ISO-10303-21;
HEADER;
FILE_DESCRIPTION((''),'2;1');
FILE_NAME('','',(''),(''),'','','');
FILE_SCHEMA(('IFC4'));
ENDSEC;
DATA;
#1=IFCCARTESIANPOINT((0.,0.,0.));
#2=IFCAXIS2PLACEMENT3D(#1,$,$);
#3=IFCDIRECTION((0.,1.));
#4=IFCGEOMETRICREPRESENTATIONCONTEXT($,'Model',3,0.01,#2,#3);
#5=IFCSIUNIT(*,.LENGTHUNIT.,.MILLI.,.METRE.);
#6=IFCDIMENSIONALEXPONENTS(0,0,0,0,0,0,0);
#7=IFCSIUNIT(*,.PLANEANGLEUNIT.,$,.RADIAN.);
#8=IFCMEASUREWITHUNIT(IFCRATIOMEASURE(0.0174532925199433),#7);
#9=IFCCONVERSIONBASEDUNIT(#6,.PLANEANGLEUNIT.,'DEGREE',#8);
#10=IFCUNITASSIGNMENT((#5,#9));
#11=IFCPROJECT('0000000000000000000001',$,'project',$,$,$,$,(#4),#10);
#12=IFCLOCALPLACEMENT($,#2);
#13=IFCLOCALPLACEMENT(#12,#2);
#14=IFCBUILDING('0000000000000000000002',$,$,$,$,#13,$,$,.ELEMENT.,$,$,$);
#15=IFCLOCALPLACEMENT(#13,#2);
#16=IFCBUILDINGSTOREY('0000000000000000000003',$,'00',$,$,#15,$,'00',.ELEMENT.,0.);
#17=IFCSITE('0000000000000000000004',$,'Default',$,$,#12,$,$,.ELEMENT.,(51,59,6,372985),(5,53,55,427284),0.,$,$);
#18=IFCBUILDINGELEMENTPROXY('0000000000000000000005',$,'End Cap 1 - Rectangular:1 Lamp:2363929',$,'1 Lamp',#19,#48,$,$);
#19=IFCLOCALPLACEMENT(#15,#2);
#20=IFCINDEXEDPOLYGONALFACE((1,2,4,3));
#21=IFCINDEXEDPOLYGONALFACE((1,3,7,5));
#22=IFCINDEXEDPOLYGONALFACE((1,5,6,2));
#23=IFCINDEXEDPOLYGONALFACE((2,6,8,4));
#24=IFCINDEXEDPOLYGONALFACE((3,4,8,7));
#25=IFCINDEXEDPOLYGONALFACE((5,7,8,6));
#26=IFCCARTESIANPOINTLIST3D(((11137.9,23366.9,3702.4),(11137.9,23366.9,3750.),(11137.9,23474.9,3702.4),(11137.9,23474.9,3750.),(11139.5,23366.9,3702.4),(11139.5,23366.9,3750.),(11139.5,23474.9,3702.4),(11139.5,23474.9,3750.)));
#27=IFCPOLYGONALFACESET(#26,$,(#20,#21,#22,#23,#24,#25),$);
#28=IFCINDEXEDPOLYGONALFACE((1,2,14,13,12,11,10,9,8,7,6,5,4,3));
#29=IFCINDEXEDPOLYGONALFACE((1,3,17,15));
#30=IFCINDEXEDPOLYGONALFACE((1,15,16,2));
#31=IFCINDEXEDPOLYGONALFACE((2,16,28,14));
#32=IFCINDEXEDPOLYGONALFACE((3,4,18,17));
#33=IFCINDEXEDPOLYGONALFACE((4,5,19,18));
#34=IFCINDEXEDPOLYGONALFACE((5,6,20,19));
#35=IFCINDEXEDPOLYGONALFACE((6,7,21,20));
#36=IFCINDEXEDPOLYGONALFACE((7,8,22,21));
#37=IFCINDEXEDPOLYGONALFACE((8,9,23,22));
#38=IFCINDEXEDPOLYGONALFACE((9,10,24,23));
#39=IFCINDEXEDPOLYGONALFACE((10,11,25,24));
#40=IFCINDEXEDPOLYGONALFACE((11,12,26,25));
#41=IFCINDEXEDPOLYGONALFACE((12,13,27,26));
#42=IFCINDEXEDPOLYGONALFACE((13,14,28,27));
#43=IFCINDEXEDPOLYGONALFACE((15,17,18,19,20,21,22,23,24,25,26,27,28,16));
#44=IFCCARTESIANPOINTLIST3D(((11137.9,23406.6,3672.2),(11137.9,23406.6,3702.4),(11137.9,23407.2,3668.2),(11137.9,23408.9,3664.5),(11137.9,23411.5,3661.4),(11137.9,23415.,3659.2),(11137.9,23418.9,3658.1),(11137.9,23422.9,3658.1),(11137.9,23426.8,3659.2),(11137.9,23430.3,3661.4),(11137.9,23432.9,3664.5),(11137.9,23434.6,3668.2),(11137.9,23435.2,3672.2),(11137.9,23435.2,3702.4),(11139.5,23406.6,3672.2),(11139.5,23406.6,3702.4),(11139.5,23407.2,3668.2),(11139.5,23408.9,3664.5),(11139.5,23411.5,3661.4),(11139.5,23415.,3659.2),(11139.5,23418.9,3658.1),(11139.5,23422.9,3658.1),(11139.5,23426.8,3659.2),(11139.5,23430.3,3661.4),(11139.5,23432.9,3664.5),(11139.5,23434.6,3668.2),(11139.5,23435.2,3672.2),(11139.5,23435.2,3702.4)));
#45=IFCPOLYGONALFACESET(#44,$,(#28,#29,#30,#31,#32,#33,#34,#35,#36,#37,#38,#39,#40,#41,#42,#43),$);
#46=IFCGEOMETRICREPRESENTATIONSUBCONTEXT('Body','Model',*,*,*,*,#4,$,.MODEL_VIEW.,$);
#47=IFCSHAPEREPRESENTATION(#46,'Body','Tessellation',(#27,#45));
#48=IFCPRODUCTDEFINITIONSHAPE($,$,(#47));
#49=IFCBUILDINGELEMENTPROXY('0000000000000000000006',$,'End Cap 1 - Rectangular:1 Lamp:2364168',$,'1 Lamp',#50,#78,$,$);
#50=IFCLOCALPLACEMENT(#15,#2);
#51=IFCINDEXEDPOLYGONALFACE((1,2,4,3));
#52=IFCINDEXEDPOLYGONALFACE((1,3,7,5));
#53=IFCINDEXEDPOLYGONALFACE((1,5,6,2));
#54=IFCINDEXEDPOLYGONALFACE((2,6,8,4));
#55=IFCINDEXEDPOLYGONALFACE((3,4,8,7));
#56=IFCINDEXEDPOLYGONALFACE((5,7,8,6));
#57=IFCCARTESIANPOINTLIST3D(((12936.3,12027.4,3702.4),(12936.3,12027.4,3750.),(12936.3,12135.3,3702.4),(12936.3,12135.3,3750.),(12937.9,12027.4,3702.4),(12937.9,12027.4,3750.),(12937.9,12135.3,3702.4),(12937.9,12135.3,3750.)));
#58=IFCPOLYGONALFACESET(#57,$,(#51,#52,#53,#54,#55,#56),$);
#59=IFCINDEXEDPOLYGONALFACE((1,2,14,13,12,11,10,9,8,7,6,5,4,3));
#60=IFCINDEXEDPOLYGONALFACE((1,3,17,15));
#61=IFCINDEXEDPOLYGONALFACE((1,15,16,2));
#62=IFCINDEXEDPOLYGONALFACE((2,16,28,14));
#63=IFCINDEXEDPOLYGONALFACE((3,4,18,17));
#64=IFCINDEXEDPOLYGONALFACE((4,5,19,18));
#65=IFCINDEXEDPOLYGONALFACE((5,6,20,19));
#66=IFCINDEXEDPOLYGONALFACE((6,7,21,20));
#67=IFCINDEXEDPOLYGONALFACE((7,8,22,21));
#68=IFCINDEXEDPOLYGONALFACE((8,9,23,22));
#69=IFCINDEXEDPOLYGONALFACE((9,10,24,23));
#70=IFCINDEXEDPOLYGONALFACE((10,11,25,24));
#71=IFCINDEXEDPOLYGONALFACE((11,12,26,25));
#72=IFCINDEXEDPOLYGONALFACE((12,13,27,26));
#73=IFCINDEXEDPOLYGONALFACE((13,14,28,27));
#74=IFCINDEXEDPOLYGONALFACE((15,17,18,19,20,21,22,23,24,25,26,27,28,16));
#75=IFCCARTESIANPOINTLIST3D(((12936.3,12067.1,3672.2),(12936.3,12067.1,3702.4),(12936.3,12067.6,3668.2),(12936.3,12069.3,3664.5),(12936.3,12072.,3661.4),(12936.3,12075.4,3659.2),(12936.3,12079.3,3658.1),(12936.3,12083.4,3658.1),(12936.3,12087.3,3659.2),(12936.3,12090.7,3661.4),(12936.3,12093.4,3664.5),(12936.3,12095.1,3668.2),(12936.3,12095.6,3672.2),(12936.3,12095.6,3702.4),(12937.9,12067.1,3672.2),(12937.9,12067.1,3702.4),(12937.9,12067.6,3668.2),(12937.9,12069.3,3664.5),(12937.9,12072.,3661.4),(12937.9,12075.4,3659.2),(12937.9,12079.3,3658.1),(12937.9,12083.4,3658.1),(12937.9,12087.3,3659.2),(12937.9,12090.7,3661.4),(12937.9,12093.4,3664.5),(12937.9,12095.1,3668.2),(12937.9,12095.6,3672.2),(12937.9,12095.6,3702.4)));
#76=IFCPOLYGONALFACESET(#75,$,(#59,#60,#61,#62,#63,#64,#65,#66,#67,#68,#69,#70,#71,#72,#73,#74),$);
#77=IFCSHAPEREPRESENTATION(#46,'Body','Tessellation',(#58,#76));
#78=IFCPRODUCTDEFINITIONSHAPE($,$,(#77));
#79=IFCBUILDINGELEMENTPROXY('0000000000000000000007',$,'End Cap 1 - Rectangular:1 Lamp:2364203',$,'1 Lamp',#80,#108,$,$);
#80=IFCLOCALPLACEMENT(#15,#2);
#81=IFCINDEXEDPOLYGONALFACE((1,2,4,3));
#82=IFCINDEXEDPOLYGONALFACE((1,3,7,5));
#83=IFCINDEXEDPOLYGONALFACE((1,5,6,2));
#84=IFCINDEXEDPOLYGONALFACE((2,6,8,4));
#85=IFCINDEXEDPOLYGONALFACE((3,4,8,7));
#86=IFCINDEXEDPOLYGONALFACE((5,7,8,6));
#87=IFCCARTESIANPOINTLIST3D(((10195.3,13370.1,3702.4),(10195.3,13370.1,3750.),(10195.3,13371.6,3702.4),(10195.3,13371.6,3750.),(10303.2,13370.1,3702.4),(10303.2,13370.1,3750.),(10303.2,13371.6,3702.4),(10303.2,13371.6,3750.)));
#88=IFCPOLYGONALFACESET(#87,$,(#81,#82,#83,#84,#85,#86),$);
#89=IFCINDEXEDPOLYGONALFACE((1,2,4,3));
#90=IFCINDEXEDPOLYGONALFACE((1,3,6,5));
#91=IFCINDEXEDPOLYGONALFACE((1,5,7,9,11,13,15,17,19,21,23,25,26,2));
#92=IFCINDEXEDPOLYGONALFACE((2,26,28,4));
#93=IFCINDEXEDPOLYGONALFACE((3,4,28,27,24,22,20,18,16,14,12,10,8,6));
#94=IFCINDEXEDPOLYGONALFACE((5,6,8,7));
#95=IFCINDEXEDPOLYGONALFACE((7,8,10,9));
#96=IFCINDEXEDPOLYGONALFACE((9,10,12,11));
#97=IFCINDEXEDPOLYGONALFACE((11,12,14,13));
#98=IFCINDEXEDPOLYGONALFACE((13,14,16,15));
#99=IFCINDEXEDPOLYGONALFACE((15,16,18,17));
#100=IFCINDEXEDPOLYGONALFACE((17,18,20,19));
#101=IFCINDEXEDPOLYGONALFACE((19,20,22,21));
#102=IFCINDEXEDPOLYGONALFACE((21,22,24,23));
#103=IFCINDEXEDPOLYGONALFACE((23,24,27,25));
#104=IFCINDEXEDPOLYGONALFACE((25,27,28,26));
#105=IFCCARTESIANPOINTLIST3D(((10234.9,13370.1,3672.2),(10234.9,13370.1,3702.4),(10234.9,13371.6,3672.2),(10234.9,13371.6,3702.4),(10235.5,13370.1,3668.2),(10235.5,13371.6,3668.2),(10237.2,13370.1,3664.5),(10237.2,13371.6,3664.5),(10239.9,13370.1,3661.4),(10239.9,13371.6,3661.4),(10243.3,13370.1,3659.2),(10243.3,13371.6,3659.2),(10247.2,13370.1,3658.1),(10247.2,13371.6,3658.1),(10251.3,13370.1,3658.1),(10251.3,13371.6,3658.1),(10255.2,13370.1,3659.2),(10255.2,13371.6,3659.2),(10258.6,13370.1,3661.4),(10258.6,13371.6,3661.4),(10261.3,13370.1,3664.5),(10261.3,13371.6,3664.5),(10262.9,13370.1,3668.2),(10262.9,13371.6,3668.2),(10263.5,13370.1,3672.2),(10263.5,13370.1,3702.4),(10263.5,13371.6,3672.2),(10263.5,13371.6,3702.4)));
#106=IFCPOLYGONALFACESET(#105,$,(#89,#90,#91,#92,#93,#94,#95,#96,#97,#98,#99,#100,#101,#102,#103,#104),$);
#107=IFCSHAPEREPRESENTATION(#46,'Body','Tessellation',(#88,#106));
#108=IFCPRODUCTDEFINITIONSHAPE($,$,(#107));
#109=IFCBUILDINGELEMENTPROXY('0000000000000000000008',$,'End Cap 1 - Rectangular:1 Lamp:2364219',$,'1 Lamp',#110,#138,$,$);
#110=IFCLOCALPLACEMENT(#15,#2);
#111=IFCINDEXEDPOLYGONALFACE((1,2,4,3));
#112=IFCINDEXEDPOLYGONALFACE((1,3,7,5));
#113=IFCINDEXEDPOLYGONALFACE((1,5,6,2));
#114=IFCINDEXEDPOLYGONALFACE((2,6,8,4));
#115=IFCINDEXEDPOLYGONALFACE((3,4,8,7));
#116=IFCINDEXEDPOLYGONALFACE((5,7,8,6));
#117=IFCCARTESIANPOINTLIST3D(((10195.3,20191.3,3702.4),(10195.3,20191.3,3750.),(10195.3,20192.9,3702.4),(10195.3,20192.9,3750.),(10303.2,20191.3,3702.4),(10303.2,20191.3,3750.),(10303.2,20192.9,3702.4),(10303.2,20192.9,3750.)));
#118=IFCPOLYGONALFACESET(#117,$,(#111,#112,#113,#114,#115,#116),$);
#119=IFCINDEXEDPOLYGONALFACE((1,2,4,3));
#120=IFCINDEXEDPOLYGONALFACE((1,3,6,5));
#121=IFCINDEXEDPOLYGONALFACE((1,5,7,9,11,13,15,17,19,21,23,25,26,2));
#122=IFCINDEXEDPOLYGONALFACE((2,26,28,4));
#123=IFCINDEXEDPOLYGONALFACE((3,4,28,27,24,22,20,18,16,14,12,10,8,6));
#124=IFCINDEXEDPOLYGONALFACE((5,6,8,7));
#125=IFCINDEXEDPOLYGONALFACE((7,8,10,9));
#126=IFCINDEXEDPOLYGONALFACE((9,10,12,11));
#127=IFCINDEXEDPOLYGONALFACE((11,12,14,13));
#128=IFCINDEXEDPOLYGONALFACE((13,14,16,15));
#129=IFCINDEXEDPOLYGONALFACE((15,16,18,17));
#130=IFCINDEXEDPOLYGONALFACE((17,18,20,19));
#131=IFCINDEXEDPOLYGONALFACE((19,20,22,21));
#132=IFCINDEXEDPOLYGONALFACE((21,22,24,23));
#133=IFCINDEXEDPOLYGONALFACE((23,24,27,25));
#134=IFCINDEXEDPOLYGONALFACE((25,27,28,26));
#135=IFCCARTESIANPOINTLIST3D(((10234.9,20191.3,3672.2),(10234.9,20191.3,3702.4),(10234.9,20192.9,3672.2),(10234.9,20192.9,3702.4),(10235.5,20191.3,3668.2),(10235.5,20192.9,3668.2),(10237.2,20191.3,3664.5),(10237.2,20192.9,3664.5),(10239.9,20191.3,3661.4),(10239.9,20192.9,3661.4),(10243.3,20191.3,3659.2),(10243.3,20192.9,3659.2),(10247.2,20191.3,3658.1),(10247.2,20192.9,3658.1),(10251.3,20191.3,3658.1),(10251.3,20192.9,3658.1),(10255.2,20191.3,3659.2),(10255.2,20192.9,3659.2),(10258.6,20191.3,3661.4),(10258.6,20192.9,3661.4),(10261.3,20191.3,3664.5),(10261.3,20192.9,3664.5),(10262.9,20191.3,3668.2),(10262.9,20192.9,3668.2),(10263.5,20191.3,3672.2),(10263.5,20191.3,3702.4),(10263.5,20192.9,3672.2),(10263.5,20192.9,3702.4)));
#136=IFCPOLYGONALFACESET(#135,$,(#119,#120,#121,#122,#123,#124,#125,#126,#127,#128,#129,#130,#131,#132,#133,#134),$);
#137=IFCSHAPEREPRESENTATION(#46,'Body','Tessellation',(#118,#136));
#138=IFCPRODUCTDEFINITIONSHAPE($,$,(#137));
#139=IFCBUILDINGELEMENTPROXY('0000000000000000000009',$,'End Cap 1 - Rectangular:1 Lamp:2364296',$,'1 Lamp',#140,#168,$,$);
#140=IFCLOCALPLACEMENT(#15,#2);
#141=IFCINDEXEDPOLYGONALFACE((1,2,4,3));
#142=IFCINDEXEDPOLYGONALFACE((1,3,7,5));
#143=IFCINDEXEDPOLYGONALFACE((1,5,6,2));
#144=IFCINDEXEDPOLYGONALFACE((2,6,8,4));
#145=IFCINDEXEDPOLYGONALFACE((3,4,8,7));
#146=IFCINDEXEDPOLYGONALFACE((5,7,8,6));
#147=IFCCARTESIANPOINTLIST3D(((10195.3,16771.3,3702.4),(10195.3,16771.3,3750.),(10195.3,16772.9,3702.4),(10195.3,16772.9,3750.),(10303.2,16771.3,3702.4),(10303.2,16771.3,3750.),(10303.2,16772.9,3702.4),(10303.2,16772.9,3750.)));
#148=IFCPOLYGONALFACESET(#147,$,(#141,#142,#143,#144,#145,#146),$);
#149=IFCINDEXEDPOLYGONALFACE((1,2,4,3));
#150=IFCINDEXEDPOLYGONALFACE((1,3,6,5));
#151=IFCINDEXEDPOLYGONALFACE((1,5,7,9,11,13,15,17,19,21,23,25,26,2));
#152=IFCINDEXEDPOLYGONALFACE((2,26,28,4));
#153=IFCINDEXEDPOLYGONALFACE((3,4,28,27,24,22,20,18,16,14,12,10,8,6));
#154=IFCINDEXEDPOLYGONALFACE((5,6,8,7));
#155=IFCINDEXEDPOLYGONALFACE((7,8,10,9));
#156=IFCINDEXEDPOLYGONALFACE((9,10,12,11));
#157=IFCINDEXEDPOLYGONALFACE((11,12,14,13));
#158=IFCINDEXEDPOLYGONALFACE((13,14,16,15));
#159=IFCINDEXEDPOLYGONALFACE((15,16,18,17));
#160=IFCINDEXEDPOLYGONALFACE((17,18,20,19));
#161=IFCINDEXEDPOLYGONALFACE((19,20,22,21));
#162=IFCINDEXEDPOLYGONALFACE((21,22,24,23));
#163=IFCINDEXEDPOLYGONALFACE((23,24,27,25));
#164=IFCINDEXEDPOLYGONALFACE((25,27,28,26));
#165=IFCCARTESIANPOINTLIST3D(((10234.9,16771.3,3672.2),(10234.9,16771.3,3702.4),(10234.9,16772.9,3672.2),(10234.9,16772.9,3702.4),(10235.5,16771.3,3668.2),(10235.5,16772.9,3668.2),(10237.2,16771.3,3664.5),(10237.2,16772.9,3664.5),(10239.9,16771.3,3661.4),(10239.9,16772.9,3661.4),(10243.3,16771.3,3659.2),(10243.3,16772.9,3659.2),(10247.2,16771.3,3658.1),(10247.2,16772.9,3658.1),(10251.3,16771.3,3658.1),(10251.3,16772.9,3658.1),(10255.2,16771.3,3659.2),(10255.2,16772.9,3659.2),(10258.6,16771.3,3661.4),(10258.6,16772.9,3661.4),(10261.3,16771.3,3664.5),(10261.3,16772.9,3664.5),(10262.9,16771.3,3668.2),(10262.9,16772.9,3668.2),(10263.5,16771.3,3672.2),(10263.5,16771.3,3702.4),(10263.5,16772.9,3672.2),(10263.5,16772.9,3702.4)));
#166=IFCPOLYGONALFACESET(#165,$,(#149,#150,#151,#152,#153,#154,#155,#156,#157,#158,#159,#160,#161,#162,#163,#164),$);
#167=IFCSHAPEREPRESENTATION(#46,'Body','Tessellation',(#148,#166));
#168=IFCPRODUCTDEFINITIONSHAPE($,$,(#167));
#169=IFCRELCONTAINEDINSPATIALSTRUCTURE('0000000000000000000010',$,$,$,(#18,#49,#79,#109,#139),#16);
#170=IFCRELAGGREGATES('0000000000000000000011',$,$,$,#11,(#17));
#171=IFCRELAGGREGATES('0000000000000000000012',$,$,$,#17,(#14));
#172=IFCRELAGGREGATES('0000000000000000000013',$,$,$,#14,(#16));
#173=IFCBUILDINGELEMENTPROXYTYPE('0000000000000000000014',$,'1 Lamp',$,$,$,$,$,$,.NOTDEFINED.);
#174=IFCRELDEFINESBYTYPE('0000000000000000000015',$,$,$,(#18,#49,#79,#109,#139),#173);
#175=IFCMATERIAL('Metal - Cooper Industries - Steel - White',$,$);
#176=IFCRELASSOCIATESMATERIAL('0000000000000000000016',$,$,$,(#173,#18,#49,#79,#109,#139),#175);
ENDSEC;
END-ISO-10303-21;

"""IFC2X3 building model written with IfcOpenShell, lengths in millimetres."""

from ifc_helpers import new_model, entity, si_unit, converted_unit, direction, frame, frame_2d, origin, origin_2d_with_axis, place, context, subcontext, project, spatial, polyline, circle_curve, parameter, trimmed, segment, composite_curve, rectangle, outline, extrude, source, transform, mapped, material, type_object, type_shapes, element, save


model = new_model("IFC2X3")

# Units and contexts
model_context = context("Model", 3, precision=0.01, world=origin(), true_north=direction((0.0, 1.0)))
body_context = subcontext(model_context, "Body", "Model", "MODEL_VIEW")
ifc_project = project(units=[si_unit("LENGTHUNIT", "METRE", prefix="MILLI"), converted_unit("PLANEANGLEUNIT", "DEGREE", entity("IfcRatioMeasure", 0.0174532925199433), si_unit("PLANEANGLEUNIT", "RADIAN"), dimensions=[0, 0, 0, 0, 0, 0, 0])], contexts=[model_context])

# Site, building, storey
site_placement = place(None, origin())
site = spatial("IfcSite", under=ifc_project, at=site_placement, Name="Default", CompositionType="ELEMENT", RefLatitude=(51, 59, 6, 372985), RefLongitude=(5, 53, 55, 427284), RefElevation=0.0)
building_placement = place(site_placement, origin())
building = spatial("IfcBuilding", under=site, at=building_placement, CompositionType="ELEMENT")
storey_placement = place(building_placement, origin())
storey = spatial("IfcBuildingStorey", under=building, at=storey_placement, Name="00", LongName="00", CompositionType="ELEMENT", Elevation=0.0)

# Building element proxies
ifc_material_1 = material(Name="Metal - Cooper Industries - Steel - White")
building_element_proxy_type_1 = type_object("IfcBuildingElementProxyType", Name="1 Lamp", PredefinedType="NOTDEFINED", material=ifc_material_1)
shared_shape_1 = source(origin(), body_context, "Body", "SweptSolid", [
    extrude(rectangle(XDim=108.0, YDim=1.6, at=origin_2d_with_axis()), frame((0.0, 0.0, 0.0), z_axis=(0.0, 0.0, 1.0), x_axis=(-1.0, 0.0, 0.0)), (0.0, 0.0, 1.0), 47.6),
    extrude(outline(composite_curve([segment(polyline([(-15.1, -14.3), (15.1, -14.3)]), True, "CONTINUOUS"), segment(polyline([(15.1, -14.3), (15.1, 14.3)]), True, "CONTINUOUS"), segment(polyline([(15.1, 14.3), (-15.1, 14.3)]), True, "CONTINUOUS"), segment(trimmed(circle_curve(frame_2d((-15.1, 0.0), x_axis=(0.0, -1.0)), 14.3), [parameter(180.0)], [parameter(0.0)], True, "PARAMETER"), True, "CONTINUOUS")], self_intersect=False)), frame((0.0, -0.8, 62.7), z_axis=(0.0, 1.0, 0.0), x_axis=(0.0, 0.0, -1.0)), (0.0, 0.0, 1.0), 1.6),
])
type_shapes(building_element_proxy_type_1, [shared_shape_1])
for number, where, z_axis, x_axis, name in (
    (1, (11138.7, 23420.9, 3750.0), (0.0, 0.0, -1.0), (0.0, -1.0, 0.0), "End Cap 1 - Rectangular:1 Lamp:2363929"),
    (2, (12937.1, 12081.4, 3750.0), (0.0, 0.0, -1.0), (0.0, 1.0, 0.0), "End Cap 1 - Rectangular:1 Lamp:2364168"),
    (3, (10249.2, 13370.8, 3750.0), (0.0, 0.0, -1.0), (1.0, 0.0, 0.0), "End Cap 1 - Rectangular:1 Lamp:2364203"),
    (4, (10249.2, 20192.1, 3750.0), (0.0, 0.0, -1.0), (1.0, 0.0, 0.0), "End Cap 1 - Rectangular:1 Lamp:2364219"),
    (5, (10249.2, 16772.1, 3750.0), (0.0, 0.0, -1.0), (1.0, 0.0, 0.0), "End Cap 1 - Rectangular:1 Lamp:2364296"),
):
    element("IfcBuildingElementProxy", number, at=place(storey_placement, frame(where, z_axis=z_axis, x_axis=x_axis)), inside=storey, type_object=building_element_proxy_type_1, material=ifc_material_1, Name=name, ObjectType="1 Lamp", context=body_context, shape_type="MappedRepresentation", body=[
        mapped(shared_shape_1, transform((0.0, 0.0, 0.0), scale=1.0)),
    ])

save(model, "model.ifc")
